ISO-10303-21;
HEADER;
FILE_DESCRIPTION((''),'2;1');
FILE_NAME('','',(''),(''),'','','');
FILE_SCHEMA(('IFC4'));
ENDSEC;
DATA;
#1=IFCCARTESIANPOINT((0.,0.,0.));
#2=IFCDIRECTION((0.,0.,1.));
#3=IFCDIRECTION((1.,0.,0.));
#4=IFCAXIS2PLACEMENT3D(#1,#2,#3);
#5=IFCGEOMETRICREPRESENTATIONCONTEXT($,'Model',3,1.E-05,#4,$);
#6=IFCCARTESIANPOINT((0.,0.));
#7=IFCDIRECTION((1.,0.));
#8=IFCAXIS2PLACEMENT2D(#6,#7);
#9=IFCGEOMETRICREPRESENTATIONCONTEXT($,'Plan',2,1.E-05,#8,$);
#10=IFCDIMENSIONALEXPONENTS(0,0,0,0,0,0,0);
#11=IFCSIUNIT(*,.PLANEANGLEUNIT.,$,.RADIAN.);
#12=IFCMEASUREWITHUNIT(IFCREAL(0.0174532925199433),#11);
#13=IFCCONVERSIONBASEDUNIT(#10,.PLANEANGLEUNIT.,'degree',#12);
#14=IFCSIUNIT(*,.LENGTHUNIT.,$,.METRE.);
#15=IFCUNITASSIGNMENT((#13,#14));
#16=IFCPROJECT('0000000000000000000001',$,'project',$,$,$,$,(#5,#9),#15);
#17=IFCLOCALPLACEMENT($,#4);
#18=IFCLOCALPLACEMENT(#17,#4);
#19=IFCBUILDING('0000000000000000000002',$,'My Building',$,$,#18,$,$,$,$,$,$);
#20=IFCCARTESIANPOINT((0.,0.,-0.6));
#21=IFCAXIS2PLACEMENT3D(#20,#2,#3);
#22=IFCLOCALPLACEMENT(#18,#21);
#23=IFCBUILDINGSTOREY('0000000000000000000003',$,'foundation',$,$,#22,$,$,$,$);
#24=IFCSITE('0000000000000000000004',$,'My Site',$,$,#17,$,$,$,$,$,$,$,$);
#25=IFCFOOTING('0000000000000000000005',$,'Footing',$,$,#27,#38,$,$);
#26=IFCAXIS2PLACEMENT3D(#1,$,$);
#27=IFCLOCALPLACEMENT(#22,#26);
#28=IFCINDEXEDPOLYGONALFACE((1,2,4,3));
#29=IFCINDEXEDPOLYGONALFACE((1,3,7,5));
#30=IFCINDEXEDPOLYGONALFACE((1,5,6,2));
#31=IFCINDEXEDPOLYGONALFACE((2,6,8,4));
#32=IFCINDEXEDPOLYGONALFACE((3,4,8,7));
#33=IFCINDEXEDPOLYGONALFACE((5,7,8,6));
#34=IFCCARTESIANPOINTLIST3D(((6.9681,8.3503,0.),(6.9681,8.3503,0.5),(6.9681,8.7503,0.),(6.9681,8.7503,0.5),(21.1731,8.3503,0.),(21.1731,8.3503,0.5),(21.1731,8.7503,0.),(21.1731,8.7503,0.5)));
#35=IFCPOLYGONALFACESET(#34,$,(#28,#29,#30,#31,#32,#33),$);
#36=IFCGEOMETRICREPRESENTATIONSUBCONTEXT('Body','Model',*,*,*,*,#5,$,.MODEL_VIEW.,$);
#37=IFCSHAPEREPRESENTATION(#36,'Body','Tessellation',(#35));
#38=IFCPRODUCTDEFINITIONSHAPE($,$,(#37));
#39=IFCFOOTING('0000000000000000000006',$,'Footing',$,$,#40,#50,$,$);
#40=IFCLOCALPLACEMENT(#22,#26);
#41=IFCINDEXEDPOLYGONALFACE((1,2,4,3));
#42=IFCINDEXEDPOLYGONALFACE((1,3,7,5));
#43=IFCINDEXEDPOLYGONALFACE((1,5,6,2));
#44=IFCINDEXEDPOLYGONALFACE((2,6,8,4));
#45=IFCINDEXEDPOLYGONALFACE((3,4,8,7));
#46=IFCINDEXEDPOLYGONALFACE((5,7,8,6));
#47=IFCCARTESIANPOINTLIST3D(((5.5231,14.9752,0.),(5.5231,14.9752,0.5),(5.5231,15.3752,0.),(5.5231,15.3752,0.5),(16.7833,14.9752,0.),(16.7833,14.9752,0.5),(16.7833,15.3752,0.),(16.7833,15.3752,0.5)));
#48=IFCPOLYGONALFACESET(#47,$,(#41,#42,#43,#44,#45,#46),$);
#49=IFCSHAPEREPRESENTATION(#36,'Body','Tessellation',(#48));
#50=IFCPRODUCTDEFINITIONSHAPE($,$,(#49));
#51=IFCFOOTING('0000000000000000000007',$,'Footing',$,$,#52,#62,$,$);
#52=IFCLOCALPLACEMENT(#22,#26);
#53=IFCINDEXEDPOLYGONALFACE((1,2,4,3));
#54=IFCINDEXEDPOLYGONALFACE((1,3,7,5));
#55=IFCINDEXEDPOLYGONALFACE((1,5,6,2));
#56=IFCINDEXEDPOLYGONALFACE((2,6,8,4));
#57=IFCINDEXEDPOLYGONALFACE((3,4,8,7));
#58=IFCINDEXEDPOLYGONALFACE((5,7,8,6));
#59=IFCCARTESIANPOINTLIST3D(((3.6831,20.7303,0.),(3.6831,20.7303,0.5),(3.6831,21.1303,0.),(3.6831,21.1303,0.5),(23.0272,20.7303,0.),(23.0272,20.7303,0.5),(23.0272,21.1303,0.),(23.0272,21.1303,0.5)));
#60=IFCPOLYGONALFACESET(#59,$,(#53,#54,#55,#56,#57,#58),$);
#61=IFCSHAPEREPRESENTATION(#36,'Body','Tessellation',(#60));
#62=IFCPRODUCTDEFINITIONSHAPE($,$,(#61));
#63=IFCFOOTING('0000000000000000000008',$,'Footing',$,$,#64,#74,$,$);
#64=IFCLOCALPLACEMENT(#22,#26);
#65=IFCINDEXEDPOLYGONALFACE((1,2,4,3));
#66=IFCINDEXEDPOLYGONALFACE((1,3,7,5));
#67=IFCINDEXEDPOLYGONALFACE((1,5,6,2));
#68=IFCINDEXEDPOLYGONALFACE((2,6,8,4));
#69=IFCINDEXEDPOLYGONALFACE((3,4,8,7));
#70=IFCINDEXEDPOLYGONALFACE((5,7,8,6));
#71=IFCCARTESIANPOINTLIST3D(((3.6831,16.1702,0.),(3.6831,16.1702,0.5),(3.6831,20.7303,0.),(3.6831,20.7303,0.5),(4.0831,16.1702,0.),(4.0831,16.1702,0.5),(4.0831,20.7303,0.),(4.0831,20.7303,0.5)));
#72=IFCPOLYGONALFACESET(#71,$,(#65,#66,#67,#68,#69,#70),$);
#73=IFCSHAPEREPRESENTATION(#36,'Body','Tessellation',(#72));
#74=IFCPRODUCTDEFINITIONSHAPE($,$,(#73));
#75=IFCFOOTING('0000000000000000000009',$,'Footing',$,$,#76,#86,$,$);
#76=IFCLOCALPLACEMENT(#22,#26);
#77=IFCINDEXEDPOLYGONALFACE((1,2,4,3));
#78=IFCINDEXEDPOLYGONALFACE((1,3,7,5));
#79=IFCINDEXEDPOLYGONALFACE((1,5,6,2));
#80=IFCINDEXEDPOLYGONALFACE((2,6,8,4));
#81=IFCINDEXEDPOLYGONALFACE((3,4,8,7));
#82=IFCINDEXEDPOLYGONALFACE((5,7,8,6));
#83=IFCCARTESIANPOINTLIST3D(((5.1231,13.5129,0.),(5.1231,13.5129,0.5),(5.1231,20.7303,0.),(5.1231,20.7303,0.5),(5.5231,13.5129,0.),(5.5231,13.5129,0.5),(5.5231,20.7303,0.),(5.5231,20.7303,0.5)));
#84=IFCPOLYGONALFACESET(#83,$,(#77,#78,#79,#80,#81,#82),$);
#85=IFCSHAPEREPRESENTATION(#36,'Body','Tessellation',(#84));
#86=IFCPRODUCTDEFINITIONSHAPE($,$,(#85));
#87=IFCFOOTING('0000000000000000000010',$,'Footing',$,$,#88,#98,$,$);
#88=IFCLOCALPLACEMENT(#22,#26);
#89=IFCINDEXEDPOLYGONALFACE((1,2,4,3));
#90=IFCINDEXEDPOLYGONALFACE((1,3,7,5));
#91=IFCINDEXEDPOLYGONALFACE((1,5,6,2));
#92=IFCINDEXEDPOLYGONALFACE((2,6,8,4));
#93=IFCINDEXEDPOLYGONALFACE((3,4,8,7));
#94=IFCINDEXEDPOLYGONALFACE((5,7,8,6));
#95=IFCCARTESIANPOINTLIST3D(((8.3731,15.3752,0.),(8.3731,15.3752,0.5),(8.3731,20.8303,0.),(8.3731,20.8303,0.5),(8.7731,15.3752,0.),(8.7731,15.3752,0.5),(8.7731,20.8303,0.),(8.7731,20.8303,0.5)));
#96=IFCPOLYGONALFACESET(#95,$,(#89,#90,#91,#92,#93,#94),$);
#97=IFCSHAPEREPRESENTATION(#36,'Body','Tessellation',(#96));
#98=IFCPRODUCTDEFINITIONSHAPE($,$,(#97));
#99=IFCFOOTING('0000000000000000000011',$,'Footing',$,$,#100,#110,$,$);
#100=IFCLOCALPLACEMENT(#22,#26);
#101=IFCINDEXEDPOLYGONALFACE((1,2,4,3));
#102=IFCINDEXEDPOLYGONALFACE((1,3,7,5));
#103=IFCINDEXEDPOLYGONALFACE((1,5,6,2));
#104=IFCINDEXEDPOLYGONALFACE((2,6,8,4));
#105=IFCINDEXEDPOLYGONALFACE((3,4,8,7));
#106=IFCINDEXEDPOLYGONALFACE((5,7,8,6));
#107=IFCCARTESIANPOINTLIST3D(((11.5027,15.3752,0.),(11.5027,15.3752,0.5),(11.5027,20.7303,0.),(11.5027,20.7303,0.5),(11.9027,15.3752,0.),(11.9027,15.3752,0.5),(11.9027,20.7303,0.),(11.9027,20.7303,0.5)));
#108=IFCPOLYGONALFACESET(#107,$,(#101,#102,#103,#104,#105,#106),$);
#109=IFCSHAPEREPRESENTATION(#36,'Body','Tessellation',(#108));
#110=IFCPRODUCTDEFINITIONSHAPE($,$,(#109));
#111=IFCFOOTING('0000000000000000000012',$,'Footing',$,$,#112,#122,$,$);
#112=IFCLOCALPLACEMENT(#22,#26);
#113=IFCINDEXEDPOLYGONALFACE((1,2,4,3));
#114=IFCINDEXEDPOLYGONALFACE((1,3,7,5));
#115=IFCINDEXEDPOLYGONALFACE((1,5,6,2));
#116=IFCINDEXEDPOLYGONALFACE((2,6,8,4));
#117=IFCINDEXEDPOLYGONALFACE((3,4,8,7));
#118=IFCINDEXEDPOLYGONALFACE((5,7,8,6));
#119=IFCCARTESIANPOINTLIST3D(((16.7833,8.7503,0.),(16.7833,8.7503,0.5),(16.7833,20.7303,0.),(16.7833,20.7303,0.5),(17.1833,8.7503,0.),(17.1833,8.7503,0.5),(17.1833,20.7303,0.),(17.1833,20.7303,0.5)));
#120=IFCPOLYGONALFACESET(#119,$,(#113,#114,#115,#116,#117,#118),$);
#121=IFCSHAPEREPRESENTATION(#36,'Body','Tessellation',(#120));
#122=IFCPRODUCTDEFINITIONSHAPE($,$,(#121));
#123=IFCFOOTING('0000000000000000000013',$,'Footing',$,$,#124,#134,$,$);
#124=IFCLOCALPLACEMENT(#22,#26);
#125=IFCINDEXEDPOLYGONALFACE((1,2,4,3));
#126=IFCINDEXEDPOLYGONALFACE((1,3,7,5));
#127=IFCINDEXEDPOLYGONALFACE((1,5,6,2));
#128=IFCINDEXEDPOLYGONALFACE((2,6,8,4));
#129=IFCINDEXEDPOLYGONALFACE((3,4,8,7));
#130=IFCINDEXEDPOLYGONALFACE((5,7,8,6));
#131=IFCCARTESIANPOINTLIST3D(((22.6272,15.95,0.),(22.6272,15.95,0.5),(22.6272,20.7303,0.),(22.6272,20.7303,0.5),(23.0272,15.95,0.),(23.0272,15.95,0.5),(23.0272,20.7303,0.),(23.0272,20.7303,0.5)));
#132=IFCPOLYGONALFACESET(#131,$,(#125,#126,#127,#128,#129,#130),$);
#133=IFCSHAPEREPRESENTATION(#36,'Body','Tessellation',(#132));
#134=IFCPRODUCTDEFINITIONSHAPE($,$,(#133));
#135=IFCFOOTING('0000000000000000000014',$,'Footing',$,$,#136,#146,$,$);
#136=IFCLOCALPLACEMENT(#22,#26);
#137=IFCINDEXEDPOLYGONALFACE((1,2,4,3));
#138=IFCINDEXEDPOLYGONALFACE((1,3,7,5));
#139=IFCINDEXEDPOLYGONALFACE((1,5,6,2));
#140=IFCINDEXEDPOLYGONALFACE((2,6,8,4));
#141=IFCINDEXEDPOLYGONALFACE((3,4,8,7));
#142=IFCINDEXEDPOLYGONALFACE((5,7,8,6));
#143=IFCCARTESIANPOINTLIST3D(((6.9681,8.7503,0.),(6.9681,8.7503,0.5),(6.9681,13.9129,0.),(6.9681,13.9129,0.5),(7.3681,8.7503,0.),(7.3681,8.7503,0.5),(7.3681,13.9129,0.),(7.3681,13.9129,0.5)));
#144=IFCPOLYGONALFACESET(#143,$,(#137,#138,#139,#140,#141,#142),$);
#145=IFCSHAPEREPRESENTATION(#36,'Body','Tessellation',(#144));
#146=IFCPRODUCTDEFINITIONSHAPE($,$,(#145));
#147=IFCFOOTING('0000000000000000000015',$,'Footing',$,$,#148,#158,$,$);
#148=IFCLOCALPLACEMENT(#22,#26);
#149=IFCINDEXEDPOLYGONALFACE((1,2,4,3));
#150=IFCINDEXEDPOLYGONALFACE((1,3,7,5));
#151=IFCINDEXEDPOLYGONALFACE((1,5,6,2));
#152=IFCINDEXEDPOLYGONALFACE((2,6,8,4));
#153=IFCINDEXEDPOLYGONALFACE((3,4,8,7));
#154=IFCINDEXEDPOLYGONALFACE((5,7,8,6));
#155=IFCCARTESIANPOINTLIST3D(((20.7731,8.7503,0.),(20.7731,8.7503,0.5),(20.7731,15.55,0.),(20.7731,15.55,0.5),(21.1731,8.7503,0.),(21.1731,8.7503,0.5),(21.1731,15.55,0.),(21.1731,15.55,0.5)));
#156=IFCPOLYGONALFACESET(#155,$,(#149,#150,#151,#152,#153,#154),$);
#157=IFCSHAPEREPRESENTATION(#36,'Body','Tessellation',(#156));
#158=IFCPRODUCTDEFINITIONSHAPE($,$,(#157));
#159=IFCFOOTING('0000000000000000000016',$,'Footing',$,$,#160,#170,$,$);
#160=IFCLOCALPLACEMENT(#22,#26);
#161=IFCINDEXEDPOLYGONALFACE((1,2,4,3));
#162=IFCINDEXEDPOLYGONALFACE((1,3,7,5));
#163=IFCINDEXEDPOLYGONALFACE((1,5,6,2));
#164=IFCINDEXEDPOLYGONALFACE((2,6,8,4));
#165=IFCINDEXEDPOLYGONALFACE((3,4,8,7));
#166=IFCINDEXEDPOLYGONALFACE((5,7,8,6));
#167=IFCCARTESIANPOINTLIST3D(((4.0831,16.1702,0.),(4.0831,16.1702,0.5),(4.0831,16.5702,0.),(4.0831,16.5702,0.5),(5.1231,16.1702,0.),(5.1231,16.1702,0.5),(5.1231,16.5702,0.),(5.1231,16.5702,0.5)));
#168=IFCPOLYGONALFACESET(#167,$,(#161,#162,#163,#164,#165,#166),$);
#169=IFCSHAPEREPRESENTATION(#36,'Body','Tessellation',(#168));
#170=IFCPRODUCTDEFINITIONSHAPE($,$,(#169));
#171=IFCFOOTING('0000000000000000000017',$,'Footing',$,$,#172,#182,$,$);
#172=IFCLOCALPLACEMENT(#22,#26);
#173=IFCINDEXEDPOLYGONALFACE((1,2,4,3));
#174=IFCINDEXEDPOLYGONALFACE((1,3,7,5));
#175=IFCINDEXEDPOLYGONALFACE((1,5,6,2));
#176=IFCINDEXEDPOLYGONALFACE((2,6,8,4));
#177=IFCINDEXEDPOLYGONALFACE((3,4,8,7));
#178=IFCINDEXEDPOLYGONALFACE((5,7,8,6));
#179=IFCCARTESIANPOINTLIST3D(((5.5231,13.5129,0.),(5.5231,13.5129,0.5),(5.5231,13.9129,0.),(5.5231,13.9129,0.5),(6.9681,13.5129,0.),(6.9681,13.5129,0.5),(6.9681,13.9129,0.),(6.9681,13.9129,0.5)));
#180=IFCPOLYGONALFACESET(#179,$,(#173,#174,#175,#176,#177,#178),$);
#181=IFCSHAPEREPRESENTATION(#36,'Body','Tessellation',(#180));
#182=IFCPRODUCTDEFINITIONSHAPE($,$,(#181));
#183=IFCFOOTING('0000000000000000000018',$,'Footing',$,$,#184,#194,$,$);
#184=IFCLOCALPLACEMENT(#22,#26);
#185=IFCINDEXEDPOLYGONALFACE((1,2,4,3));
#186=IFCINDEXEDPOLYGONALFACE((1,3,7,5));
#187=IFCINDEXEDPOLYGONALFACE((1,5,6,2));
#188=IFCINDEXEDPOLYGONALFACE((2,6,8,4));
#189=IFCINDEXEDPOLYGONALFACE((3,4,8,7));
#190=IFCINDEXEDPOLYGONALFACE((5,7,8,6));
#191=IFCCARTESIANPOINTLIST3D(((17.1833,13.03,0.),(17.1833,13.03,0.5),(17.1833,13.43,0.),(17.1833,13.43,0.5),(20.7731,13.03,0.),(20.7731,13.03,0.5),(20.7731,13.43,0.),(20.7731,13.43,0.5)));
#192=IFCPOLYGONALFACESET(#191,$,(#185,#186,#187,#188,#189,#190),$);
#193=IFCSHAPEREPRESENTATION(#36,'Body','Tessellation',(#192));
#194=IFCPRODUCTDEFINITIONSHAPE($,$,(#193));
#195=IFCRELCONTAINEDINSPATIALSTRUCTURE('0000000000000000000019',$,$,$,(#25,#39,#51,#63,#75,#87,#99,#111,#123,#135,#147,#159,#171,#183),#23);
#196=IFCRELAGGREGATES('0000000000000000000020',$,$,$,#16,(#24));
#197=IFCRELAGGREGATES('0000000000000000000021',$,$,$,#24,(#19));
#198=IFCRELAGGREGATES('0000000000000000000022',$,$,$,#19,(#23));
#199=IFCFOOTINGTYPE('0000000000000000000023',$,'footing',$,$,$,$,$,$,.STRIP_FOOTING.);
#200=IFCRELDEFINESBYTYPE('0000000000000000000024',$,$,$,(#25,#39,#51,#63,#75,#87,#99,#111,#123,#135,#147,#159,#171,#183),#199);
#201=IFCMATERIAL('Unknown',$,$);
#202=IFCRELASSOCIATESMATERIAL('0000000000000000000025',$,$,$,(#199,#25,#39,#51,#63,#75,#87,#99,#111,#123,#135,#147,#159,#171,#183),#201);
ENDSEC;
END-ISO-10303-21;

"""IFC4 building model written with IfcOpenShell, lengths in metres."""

from ifc_helpers import new_model, entity, si_unit, converted_unit, frame, origin_with_axes, origin_2d_with_axis, place, context, subcontext, project, spatial, rectangle, extrude, material, material_profile, profile_set, profile_usage, type_object, element, save


model = new_model("IFC4")

# Units and contexts
model_context = context("Model", 3, precision=1e-05, world=origin_with_axes())
plan_context = context("Plan", 2, precision=1e-05, world=origin_2d_with_axis())
body_context = subcontext(model_context, "Body", "Model", "MODEL_VIEW")
ifc_project = project(units=[converted_unit("PLANEANGLEUNIT", "degree", entity("IfcReal", 0.0174532925199433), si_unit("PLANEANGLEUNIT", "RADIAN"), dimensions=[0, 0, 0, 0, 0, 0, 0]), si_unit("LENGTHUNIT", "METRE")], contexts=[model_context, plan_context])

# Site, building, storey
site_placement = place(None, origin_with_axes())
site = spatial("IfcSite", under=ifc_project, at=site_placement, Name="My Site")
building_placement = place(site_placement, origin_with_axes())
building = spatial("IfcBuilding", under=site, at=building_placement, Name="My Building")
storey_placement = place(building_placement, frame((0.0, 0.0, -0.6), z_axis=(0.0, 0.0, 1.0), x_axis=(1.0, 0.0, 0.0)))
storey = spatial("IfcBuildingStorey", under=building, at=storey_placement, Name="foundation")

# Footings
ifc_material = material(Name="Unknown")
ifc_material_profile = material_profile(ifc_material, rectangle(XDim=0.4, YDim=0.5))
ifc_profile_set = profile_set([ifc_material_profile])
ifc_profile_usage_1 = profile_usage(ifc_profile_set, cardinal=1)
footing_type = type_object("IfcFootingType", Name="footing", PredefinedType="STRIP_FOOTING", material=ifc_profile_set)
footing_1_placement = place(storey_placement, frame((6.9681, 8.7503, 0.0), z_axis=(1.0, 0.0, 0.0), x_axis=(0.0, 1.0, 0.0)))
element("IfcFooting", 1, at=footing_1_placement, inside=storey, type_object=footing_type, material=ifc_profile_usage_1, Name="Footing", context=body_context, shape_type="SweptSolid", body=[
    extrude(rectangle(XDim=0.4, YDim=0.5), frame((-0.2, 0.25, 0.0), z_axis=(0.0, 0.0, 1.0), x_axis=(1.0, 0.0, 0.0)), (0.0, 0.0, 1.0), 14.205),
])
ifc_profile_usage_2 = profile_usage(ifc_profile_set, cardinal=1)
footing_2_placement = place(storey_placement, frame((5.5231, 15.3752, 0.0), z_axis=(1.0, 0.0, 0.0), x_axis=(0.0, 1.0, 0.0)))
element("IfcFooting", 2, at=footing_2_placement, inside=storey, type_object=footing_type, material=ifc_profile_usage_2, Name="Footing", context=body_context, shape_type="SweptSolid", body=[
    extrude(rectangle(XDim=0.4, YDim=0.5), frame((-0.2, 0.25, 0.0), z_axis=(0.0, 0.0, 1.0), x_axis=(1.0, 0.0, 0.0)), (0.0, 0.0, 1.0), 11.2602),
])
ifc_profile_usage_3 = profile_usage(ifc_profile_set, cardinal=1)
footing_3_placement = place(storey_placement, frame((3.6831, 21.1303, 0.0), z_axis=(1.0, 0.0, 0.0), x_axis=(0.0, 1.0, 0.0)))
element("IfcFooting", 3, at=footing_3_placement, inside=storey, type_object=footing_type, material=ifc_profile_usage_3, Name="Footing", context=body_context, shape_type="SweptSolid", body=[
    extrude(rectangle(XDim=0.4, YDim=0.5), frame((-0.2, 0.25, 0.0), z_axis=(0.0, 0.0, 1.0), x_axis=(1.0, 0.0, 0.0)), (0.0, 0.0, 1.0), 19.3441),
])
ifc_profile_usage_4 = profile_usage(ifc_profile_set, cardinal=1)
footing_4_placement = place(storey_placement, frame((4.0831, 20.7303, 0.0), z_axis=(0.0, -1.0, 0.0), x_axis=(1.0, 0.0, 0.0)))
element("IfcFooting", 4, at=footing_4_placement, inside=storey, type_object=footing_type, material=ifc_profile_usage_4, Name="Footing", context=body_context, shape_type="SweptSolid", body=[
    extrude(rectangle(XDim=0.4, YDim=0.5), frame((-0.2, 0.25, 0.0), z_axis=(0.0, 0.0, 1.0), x_axis=(1.0, 0.0, 0.0)), (0.0, 0.0, 1.0), 4.5601),
])
ifc_profile_usage_5 = profile_usage(ifc_profile_set, cardinal=1)
footing_5_placement = place(storey_placement, frame((5.5231, 20.7303, 0.0), z_axis=(0.0, -1.0, 0.0), x_axis=(1.0, 0.0, 0.0)))
element("IfcFooting", 5, at=footing_5_placement, inside=storey, type_object=footing_type, material=ifc_profile_usage_5, Name="Footing", context=body_context, shape_type="SweptSolid", body=[
    extrude(rectangle(XDim=0.4, YDim=0.5), frame((-0.2, 0.25, 0.0), z_axis=(0.0, 0.0, 1.0), x_axis=(1.0, 0.0, 0.0)), (0.0, 0.0, 1.0), 7.2174),
])
ifc_profile_usage_6 = profile_usage(ifc_profile_set, cardinal=1)
footing_6_placement = place(storey_placement, frame((8.7731, 20.8303, 0.0), z_axis=(0.0, -1.0, 0.0), x_axis=(1.0, 0.0, 0.0)))
element("IfcFooting", 6, at=footing_6_placement, inside=storey, type_object=footing_type, material=ifc_profile_usage_6, Name="Footing", context=body_context, shape_type="SweptSolid", body=[
    extrude(rectangle(XDim=0.4, YDim=0.5), frame((-0.2, 0.25, 0.0), z_axis=(0.0, 0.0, 1.0), x_axis=(1.0, 0.0, 0.0)), (0.0, 0.0, 1.0), 5.4551),
])
ifc_profile_usage_7 = profile_usage(ifc_profile_set, cardinal=1)
footing_7_placement = place(storey_placement, frame((11.9027, 20.7303, 0.0), z_axis=(0.0, -1.0, 0.0), x_axis=(1.0, 0.0, 0.0)))
element("IfcFooting", 7, at=footing_7_placement, inside=storey, type_object=footing_type, material=ifc_profile_usage_7, Name="Footing", context=body_context, shape_type="SweptSolid", body=[
    extrude(rectangle(XDim=0.4, YDim=0.5), frame((-0.2, 0.25, 0.0), z_axis=(0.0, 0.0, 1.0), x_axis=(1.0, 0.0, 0.0)), (0.0, 0.0, 1.0), 5.3551),
])
ifc_profile_usage_8 = profile_usage(ifc_profile_set, cardinal=1)
footing_8_placement = place(storey_placement, frame((17.1833, 20.7303, 0.0), z_axis=(0.0, -1.0, 0.0), x_axis=(1.0, 0.0, 0.0)))
element("IfcFooting", 8, at=footing_8_placement, inside=storey, type_object=footing_type, material=ifc_profile_usage_8, Name="Footing", context=body_context, shape_type="SweptSolid", body=[
    extrude(rectangle(XDim=0.4, YDim=0.5), frame((-0.2, 0.25, 0.0), z_axis=(0.0, 0.0, 1.0), x_axis=(1.0, 0.0, 0.0)), (0.0, 0.0, 1.0), 11.98),
])
ifc_profile_usage_9 = profile_usage(ifc_profile_set, cardinal=1)
footing_9_placement = place(storey_placement, frame((23.0272, 20.7303, 0.0), z_axis=(0.0, -1.0, 0.0), x_axis=(1.0, 0.0, 0.0)))
element("IfcFooting", 9, at=footing_9_placement, inside=storey, type_object=footing_type, material=ifc_profile_usage_9, Name="Footing", context=body_context, shape_type="SweptSolid", body=[
    extrude(rectangle(XDim=0.4, YDim=0.5), frame((-0.2, 0.25, 0.0), z_axis=(0.0, 0.0, 1.0), x_axis=(1.0, 0.0, 0.0)), (0.0, 0.0, 1.0), 4.7804),
])
ifc_profile_usage_10 = profile_usage(ifc_profile_set, cardinal=1)
footing_10_placement = place(storey_placement, frame((7.3681, 13.9129, 0.0), z_axis=(0.0, -1.0, 0.0), x_axis=(1.0, 0.0, 0.0)))
element("IfcFooting", 10, at=footing_10_placement, inside=storey, type_object=footing_type, material=ifc_profile_usage_10, Name="Footing", context=body_context, shape_type="SweptSolid", body=[
    extrude(rectangle(XDim=0.4, YDim=0.5), frame((-0.2, 0.25, 0.0), z_axis=(0.0, 0.0, 1.0), x_axis=(1.0, 0.0, 0.0)), (0.0, 0.0, 1.0), 5.1626),
])
ifc_profile_usage_11 = profile_usage(ifc_profile_set, cardinal=1)
footing_11_placement = place(storey_placement, frame((21.1731, 15.55, 0.0), z_axis=(0.0, -1.0, 0.0), x_axis=(1.0, 0.0, 0.0)))
element("IfcFooting", 11, at=footing_11_placement, inside=storey, type_object=footing_type, material=ifc_profile_usage_11, Name="Footing", context=body_context, shape_type="SweptSolid", body=[
    extrude(rectangle(XDim=0.4, YDim=0.5), frame((-0.2, 0.25, 0.0), z_axis=(0.0, 0.0, 1.0), x_axis=(1.0, 0.0, 0.0)), (0.0, 0.0, 1.0), 6.7996),
])
ifc_profile_usage_12 = profile_usage(ifc_profile_set, cardinal=1)
footing_12_placement = place(storey_placement, frame((4.0831, 16.5702, 0.0), z_axis=(1.0, 0.0, 0.0), x_axis=(0.0, 1.0, 0.0)))
element("IfcFooting", 12, at=footing_12_placement, inside=storey, type_object=footing_type, material=ifc_profile_usage_12, Name="Footing", context=body_context, shape_type="SweptSolid", body=[
    extrude(rectangle(XDim=0.4, YDim=0.5), frame((-0.2, 0.25, 0.0), z_axis=(0.0, 0.0, 1.0), x_axis=(1.0, 0.0, 0.0)), (0.0, 0.0, 1.0), 1.04),
])
ifc_profile_usage_13 = profile_usage(ifc_profile_set, cardinal=1)
footing_13_placement = place(storey_placement, frame((5.5231, 13.9129, 0.0), z_axis=(1.0, 0.0, 0.0), x_axis=(0.0, 1.0, 0.0)))
element("IfcFooting", 13, at=footing_13_placement, inside=storey, type_object=footing_type, material=ifc_profile_usage_13, Name="Footing", context=body_context, shape_type="SweptSolid", body=[
    extrude(rectangle(XDim=0.4, YDim=0.5), frame((-0.2, 0.25, 0.0), z_axis=(0.0, 0.0, 1.0), x_axis=(1.0, 0.0, 0.0)), (0.0, 0.0, 1.0), 1.445),
])
ifc_profile_usage_14 = profile_usage(ifc_profile_set, cardinal=1)
footing_14_placement = place(storey_placement, frame((17.1833, 13.43, 0.0), z_axis=(1.0, 0.0, 0.0), x_axis=(0.0, 1.0, 0.0)))
element("IfcFooting", 14, at=footing_14_placement, inside=storey, type_object=footing_type, material=ifc_profile_usage_14, Name="Footing", context=body_context, shape_type="SweptSolid", body=[
    extrude(rectangle(XDim=0.4, YDim=0.5), frame((-0.2, 0.25, 0.0), z_axis=(0.0, 0.0, 1.0), x_axis=(1.0, 0.0, 0.0)), (0.0, 0.0, 1.0), 3.5898),
])

save(model, "model.ifc")
